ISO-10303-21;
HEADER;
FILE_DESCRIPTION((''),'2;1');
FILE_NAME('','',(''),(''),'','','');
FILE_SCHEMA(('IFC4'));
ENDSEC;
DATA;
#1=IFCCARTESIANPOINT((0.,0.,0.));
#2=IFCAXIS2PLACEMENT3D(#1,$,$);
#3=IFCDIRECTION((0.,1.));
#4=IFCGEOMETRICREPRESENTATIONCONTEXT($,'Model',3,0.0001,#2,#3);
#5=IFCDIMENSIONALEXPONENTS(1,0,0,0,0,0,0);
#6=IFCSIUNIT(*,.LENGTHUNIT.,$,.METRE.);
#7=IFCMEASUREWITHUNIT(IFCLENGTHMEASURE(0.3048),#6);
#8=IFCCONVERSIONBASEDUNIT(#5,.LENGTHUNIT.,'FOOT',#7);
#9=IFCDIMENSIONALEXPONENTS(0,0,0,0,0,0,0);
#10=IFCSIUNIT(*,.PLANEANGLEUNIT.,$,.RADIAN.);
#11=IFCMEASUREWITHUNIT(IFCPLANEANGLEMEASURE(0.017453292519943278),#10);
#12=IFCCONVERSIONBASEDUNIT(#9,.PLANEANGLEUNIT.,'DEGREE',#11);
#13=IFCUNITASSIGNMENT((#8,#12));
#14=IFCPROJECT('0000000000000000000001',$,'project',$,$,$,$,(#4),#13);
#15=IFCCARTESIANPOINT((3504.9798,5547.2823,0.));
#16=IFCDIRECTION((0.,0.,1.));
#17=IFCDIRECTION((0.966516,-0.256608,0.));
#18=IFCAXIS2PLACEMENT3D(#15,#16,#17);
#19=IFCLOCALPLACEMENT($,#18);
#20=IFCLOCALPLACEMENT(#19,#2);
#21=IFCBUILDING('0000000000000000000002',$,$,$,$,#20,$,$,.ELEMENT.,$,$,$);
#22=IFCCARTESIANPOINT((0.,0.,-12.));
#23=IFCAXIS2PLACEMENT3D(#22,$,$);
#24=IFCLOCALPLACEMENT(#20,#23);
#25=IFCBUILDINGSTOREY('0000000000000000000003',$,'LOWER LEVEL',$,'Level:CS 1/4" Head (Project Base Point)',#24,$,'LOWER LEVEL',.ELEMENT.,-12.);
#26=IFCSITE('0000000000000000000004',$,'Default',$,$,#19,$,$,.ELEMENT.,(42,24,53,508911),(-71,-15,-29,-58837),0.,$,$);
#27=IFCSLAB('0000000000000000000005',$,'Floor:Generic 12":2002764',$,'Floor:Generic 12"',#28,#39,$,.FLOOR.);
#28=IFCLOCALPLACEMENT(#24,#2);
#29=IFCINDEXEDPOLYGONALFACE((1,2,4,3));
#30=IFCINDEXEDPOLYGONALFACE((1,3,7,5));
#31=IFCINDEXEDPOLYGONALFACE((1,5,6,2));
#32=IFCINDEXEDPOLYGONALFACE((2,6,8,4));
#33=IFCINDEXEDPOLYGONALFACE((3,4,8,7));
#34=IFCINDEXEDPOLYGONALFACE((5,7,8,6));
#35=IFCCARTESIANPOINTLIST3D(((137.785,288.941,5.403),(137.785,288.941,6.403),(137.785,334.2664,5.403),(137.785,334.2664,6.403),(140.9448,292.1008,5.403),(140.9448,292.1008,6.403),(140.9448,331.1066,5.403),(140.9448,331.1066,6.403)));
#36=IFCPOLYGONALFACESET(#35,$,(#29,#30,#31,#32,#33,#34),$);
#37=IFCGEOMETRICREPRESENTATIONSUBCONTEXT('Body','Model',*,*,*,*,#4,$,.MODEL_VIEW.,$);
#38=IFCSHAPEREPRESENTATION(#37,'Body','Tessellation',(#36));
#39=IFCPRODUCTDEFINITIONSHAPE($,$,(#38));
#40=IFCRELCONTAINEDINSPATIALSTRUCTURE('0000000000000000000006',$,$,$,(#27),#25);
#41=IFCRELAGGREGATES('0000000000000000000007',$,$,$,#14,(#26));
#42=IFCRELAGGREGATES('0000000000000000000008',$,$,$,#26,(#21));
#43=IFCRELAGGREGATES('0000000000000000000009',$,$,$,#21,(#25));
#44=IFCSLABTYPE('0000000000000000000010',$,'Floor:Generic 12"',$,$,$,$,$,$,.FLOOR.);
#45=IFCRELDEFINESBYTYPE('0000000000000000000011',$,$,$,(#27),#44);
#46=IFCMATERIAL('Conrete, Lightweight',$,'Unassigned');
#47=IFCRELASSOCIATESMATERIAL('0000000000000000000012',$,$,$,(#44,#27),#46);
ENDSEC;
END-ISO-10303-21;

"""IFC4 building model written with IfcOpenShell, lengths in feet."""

from ifc_helpers import new_model, entity, si_unit, converted_unit, direction, frame, origin, place, context, subcontext, project, spatial, indexed_curve, outline, extrude, material, type_object, element, save


model = new_model("IFC4")

# Units and contexts
model_context = context("Model", 3, precision=0.0001, world=origin(), true_north=direction((0.0, 1.0)))
body_context = subcontext(model_context, "Body", "Model", "MODEL_VIEW")
ifc_project = project(units=[converted_unit("LENGTHUNIT", "FOOT", entity("IfcLengthMeasure", 0.3048), si_unit("LENGTHUNIT", "METRE"), dimensions=[1, 0, 0, 0, 0, 0, 0]), converted_unit("PLANEANGLEUNIT", "DEGREE", entity("IfcPlaneAngleMeasure", 0.017453292519943278), si_unit("PLANEANGLEUNIT", "RADIAN"), dimensions=[0, 0, 0, 0, 0, 0, 0])], contexts=[model_context])

# Site, building, storey
site_placement = place(None, frame((3504.9798, 5547.2823, 0.0), z_axis=(0.0, 0.0, 1.0), x_axis=(0.966516, -0.256608, 0.0)))
site = spatial("IfcSite", under=ifc_project, at=site_placement, Name="Default", CompositionType="ELEMENT", RefLatitude=(42, 24, 53, 508911), RefLongitude=(-71, -15, -29, -58837), RefElevation=0.0)
building_placement = place(site_placement, origin())
building = spatial("IfcBuilding", under=site, at=building_placement, CompositionType="ELEMENT")
storey_placement = place(building_placement, frame((0.0, 0.0, -12.0)))
storey = spatial("IfcBuildingStorey", under=building, at=storey_placement, Name="LOWER LEVEL", ObjectType="Level:CS 1/4\" Head (Project Base Point)", LongName="LOWER LEVEL", CompositionType="ELEMENT", Elevation=-12.0)

# Slab
ifc_material_1 = material(Name="Conrete, Lightweight", Category="Unassigned")
slab_type = type_object("IfcSlabType", Name="Floor:Generic 12\"", PredefinedType="FLOOR", material=ifc_material_1)
slab_placement = place(storey_placement, origin())
element("IfcSlab", 1, at=slab_placement, inside=storey, type_object=slab_type, material=ifc_material_1, Name="Floor:Generic 12\":2002764", ObjectType="Floor:Generic 12\"", PredefinedType="FLOOR", context=body_context, shape_type="SweptSolid", body=[
    extrude(outline(indexed_curve([(-22.6627, -1.5799), (22.6627, -1.5799), (19.5029, 1.5799), (-19.5029, 1.5799), (-22.6627, -1.5799)], self_intersect=False)), frame((139.3649, 311.6037, 6.403), z_axis=(0.0, 0.0, -1.0), x_axis=(0.0, 1.0, 0.0)), (0.0, 0.0, 1.0), 1.0),
])

save(model, "model.ifc")
